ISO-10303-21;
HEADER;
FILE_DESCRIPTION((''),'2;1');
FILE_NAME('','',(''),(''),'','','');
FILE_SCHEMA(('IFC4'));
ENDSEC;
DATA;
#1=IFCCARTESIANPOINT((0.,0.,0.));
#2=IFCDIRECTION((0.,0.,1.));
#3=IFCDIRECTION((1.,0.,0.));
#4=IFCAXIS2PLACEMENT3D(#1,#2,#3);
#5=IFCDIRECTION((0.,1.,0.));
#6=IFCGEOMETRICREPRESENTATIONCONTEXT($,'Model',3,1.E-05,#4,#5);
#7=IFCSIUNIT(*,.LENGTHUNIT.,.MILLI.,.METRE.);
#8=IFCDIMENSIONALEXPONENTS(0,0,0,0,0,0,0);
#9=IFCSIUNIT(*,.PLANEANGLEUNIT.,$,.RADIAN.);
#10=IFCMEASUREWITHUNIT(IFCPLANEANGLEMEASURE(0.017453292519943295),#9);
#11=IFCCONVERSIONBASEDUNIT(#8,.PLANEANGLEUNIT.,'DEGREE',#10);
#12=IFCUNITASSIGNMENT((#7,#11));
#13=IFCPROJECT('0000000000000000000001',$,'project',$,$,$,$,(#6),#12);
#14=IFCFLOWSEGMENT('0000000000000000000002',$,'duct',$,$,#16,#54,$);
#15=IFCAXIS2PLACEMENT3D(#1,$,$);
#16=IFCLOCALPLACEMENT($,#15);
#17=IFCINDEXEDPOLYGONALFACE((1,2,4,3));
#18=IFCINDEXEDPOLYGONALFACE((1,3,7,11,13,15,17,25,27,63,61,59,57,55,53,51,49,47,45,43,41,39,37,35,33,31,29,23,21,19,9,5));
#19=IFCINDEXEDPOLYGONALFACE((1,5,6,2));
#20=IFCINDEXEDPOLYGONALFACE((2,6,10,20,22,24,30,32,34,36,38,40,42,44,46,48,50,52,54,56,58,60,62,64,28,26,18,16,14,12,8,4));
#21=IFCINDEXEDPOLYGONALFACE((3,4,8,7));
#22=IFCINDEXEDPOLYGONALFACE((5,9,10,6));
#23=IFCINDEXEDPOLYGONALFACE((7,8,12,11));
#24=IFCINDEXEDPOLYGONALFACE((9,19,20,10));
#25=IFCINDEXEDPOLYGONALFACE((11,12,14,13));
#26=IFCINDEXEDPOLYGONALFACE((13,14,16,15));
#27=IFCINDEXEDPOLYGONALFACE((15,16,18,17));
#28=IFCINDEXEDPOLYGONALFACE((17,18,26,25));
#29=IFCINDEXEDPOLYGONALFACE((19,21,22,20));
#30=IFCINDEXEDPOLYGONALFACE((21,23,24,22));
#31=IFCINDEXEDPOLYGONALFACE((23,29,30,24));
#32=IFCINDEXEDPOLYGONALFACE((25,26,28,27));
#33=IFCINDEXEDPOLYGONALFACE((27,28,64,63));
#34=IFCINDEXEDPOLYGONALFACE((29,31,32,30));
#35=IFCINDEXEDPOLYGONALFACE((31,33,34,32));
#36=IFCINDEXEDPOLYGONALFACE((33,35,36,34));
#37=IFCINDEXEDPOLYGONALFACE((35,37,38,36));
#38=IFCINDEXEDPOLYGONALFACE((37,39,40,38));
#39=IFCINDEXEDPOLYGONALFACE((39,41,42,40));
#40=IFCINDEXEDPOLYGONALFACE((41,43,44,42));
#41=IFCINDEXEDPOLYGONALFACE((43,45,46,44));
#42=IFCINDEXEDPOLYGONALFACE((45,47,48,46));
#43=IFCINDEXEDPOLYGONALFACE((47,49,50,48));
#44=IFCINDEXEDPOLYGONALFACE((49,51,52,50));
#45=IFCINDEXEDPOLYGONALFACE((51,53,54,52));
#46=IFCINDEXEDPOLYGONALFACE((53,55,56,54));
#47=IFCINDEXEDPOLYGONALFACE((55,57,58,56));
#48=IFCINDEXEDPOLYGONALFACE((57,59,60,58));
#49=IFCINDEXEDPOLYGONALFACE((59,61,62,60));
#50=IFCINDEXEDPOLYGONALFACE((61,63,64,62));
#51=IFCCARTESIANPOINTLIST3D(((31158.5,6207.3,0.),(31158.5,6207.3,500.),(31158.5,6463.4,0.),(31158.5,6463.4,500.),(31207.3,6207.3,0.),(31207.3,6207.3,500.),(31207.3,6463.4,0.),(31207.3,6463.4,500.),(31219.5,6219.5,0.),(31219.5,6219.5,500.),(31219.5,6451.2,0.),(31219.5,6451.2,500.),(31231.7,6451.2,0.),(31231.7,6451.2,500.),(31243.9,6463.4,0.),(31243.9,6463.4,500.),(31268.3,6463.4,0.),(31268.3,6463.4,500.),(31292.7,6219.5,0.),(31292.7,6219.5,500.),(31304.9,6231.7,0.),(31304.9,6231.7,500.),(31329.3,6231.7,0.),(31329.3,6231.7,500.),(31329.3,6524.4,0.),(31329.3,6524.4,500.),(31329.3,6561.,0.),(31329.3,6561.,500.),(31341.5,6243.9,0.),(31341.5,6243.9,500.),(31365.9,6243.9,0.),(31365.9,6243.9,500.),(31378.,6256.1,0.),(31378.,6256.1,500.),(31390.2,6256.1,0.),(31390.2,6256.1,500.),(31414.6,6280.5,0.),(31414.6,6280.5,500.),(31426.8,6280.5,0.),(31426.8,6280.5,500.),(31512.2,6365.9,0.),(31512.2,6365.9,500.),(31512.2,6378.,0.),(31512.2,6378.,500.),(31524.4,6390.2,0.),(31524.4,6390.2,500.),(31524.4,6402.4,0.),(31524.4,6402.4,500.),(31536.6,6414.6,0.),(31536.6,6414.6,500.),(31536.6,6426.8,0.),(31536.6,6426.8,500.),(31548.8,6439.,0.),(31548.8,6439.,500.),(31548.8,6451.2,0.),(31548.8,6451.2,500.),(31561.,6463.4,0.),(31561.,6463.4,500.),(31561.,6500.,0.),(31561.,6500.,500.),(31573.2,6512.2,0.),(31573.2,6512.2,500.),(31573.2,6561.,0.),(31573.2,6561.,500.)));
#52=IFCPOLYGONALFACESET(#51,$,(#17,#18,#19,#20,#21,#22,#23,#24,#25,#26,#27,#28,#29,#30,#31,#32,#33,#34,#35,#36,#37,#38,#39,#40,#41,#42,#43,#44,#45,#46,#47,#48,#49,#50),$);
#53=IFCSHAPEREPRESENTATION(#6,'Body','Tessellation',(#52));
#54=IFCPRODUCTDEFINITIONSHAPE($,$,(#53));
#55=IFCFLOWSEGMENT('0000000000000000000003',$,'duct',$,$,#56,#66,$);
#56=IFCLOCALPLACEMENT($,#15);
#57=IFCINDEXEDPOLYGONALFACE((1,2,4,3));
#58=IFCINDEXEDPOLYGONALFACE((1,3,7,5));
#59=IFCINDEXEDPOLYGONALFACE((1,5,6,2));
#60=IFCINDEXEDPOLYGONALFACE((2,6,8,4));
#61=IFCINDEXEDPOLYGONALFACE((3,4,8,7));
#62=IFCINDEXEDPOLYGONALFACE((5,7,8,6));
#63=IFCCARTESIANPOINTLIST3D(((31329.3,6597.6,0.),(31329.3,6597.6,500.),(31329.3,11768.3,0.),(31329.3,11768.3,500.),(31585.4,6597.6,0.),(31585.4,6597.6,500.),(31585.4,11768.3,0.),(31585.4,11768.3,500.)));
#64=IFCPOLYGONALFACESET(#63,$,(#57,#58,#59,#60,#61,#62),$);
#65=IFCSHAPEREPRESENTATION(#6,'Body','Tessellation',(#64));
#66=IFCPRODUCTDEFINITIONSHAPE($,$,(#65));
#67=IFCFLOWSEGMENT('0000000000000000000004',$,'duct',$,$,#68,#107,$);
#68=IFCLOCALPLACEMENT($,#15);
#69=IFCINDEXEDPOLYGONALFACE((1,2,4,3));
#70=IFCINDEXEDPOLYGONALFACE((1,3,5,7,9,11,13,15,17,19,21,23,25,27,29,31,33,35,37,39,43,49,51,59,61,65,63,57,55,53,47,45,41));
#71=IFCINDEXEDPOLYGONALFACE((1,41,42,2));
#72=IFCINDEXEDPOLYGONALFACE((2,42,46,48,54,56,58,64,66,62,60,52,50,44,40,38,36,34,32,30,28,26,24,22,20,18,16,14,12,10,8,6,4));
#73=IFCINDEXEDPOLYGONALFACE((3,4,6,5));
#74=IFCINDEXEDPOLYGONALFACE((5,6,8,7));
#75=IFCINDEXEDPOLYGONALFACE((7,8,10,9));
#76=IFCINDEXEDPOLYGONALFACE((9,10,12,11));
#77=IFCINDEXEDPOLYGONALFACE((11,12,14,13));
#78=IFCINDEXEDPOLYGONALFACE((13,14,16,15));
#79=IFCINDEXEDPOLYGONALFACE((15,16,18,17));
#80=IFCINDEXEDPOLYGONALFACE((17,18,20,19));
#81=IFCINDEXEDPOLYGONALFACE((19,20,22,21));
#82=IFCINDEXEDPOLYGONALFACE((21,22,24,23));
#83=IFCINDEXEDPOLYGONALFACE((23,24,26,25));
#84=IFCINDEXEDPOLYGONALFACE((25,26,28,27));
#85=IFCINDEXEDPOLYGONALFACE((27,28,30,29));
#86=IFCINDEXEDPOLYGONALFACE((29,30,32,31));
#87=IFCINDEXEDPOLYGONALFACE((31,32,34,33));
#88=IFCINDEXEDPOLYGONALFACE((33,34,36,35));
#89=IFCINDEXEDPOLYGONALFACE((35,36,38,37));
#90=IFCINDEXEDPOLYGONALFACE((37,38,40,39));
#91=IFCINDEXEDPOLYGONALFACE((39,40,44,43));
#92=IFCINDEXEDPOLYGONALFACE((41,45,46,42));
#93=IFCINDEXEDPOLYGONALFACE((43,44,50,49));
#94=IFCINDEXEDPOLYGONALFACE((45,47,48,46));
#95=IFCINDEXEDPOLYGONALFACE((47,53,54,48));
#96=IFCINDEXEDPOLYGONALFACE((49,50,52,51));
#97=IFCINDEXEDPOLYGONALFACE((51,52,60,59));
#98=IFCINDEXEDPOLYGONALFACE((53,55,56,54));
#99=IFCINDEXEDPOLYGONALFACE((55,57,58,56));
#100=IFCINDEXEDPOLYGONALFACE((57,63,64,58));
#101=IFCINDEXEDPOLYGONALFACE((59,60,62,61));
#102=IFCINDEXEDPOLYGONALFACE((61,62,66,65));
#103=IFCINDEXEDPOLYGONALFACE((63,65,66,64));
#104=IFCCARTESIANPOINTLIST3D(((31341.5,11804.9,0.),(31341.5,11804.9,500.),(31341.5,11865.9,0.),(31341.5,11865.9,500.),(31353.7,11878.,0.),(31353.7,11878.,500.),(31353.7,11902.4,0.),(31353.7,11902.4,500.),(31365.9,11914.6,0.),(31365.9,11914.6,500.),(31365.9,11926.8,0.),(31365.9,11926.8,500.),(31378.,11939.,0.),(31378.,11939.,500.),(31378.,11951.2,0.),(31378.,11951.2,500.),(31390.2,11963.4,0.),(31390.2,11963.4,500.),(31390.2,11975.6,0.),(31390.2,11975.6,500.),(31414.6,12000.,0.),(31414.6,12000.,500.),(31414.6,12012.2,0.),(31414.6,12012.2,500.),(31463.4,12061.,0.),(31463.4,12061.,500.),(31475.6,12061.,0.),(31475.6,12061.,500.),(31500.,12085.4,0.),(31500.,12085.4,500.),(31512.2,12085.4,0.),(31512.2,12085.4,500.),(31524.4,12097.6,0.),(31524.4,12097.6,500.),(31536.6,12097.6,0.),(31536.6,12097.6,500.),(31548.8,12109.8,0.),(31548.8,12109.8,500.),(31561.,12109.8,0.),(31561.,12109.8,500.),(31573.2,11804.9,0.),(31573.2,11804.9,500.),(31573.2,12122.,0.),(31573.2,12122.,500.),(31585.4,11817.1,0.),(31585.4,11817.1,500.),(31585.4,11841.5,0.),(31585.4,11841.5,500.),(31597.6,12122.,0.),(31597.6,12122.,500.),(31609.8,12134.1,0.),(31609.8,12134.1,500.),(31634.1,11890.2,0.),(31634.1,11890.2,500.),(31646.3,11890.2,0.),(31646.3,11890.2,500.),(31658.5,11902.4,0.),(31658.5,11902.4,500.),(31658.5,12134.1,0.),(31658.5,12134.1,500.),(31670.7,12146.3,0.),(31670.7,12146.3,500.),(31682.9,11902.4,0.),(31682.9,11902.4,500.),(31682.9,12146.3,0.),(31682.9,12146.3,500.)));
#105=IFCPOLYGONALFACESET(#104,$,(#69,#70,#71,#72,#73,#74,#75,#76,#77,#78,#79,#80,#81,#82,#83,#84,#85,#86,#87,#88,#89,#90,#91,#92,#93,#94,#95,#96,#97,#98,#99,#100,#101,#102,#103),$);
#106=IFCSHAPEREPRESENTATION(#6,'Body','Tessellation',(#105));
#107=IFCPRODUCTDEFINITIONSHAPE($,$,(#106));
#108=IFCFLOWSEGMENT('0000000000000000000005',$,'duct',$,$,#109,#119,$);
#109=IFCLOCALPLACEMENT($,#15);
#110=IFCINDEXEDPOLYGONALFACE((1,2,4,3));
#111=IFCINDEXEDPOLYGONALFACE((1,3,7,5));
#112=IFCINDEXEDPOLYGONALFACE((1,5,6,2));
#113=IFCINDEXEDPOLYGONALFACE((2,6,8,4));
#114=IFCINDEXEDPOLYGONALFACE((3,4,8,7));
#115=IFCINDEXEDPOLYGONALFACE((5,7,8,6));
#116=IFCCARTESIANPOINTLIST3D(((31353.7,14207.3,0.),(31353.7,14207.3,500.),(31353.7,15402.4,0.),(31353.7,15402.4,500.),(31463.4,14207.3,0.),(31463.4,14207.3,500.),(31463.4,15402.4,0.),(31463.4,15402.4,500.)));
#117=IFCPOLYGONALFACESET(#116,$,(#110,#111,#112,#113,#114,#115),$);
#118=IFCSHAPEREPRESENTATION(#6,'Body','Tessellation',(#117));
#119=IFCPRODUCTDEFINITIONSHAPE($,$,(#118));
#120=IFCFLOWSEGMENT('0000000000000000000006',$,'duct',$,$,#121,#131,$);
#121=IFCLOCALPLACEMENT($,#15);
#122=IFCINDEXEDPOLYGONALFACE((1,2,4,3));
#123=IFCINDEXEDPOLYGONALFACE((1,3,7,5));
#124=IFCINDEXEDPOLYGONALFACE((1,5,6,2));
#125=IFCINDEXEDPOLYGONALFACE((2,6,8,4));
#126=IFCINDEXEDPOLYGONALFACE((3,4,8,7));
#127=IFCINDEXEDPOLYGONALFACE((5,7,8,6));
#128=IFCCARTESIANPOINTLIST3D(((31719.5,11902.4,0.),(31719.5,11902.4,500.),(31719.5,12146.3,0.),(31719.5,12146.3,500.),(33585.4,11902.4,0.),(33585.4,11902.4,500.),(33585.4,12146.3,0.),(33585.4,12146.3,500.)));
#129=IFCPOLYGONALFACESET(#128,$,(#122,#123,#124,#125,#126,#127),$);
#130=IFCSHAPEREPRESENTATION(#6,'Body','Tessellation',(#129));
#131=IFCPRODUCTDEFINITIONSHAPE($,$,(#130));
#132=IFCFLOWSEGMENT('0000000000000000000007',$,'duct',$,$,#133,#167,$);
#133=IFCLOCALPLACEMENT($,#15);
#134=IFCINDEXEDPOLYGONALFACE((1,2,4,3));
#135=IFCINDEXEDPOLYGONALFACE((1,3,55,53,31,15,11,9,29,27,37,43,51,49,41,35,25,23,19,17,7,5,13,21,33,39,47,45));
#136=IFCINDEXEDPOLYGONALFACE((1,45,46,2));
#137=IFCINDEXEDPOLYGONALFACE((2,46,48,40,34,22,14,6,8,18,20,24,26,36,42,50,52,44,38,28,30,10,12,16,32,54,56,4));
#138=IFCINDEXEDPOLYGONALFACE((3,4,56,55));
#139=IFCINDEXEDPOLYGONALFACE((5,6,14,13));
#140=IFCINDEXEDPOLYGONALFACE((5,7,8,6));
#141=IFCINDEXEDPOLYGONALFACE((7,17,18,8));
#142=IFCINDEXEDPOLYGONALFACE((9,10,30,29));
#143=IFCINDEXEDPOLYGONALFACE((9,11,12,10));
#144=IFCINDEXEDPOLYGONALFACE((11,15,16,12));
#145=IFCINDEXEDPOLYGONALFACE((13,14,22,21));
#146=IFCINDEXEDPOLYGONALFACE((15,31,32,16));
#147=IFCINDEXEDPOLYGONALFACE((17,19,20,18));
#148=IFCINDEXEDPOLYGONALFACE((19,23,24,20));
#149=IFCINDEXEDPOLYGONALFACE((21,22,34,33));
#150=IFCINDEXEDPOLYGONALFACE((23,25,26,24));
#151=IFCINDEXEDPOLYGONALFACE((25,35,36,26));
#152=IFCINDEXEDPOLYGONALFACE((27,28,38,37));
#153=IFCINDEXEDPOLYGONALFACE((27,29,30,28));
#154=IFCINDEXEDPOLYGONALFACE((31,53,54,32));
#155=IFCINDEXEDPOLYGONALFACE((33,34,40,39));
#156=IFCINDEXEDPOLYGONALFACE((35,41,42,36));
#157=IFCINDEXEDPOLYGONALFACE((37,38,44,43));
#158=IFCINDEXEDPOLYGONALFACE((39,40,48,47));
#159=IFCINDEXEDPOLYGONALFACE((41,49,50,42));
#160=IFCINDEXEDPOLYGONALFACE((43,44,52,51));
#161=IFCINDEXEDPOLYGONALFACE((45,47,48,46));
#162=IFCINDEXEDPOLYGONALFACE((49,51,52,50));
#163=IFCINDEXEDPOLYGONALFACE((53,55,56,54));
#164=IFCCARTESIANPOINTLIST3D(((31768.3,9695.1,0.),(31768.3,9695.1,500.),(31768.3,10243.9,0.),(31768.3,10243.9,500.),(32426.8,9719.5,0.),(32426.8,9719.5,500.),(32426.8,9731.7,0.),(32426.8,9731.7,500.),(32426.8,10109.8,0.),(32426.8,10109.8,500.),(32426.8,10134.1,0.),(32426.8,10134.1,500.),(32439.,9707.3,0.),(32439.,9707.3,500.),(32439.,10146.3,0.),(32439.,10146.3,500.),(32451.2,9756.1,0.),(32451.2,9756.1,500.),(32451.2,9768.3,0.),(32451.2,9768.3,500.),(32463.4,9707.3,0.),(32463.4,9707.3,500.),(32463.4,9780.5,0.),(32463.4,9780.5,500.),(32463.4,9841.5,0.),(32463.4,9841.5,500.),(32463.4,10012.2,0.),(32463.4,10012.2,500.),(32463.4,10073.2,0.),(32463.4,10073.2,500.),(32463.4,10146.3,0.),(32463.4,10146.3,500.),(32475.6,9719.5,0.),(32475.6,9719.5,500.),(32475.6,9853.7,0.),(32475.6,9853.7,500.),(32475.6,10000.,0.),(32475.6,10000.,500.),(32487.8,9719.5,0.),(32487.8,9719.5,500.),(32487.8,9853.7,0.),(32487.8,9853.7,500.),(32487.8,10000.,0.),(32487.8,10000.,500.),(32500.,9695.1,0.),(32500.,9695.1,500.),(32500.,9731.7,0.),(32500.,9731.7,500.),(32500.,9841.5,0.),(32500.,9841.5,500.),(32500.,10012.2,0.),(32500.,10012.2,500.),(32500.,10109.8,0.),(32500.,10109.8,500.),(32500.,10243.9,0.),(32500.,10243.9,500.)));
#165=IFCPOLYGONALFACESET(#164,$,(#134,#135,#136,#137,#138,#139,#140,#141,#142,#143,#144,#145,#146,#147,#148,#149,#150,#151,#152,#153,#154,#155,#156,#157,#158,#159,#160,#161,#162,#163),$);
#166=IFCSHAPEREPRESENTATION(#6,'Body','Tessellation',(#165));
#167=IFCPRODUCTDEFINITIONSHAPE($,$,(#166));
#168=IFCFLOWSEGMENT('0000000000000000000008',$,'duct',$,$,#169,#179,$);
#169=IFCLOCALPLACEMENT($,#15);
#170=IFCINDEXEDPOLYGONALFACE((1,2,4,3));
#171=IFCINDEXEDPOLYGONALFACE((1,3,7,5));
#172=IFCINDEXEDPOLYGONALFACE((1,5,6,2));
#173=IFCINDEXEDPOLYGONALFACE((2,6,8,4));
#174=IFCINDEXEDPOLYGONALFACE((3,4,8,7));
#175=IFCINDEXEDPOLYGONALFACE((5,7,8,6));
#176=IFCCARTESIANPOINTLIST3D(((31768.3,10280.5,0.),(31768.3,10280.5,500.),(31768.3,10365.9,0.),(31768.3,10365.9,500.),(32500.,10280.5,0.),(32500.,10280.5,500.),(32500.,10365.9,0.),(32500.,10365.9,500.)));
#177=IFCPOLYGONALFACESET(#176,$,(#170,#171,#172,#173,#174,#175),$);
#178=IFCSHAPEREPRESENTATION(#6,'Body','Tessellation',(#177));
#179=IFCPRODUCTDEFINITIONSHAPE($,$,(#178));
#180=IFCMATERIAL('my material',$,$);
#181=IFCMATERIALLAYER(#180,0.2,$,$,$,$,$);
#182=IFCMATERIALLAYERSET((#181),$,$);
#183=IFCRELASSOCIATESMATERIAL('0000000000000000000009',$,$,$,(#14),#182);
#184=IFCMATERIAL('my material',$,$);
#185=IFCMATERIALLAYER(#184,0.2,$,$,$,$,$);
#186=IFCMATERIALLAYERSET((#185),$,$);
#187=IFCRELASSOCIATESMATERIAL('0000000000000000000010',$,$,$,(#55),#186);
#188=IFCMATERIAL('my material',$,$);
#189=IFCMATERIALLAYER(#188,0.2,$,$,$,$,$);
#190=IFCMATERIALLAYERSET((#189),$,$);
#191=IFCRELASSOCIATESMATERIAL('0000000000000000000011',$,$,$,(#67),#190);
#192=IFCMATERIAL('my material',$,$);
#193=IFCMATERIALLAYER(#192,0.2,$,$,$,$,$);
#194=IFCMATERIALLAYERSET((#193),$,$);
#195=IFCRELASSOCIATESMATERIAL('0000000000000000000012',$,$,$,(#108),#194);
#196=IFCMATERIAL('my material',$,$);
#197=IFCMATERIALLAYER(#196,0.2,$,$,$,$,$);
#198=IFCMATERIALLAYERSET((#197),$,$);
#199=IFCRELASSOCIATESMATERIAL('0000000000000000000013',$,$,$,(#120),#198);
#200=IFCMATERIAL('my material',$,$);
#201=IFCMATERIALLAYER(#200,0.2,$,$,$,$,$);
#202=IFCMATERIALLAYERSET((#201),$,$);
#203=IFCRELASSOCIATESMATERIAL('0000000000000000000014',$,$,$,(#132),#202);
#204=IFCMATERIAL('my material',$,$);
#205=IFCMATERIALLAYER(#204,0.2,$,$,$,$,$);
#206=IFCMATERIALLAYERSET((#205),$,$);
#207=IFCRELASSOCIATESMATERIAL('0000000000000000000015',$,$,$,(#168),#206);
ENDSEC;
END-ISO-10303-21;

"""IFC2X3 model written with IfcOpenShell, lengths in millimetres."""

from ifc_helpers import new_model, entity, si_unit, converted_unit, direction, origin_with_axes, place, context, project, polyline, outline, extrude, material, layer, layer_set, layer_usage, element, save


model = new_model("IFC2X3")

# Units and contexts
model_context = context("Model", 3, precision=1e-05, world=origin_with_axes(), true_north=direction((0.0, 1.0, 0.0)))
ifc_project = project(units=[si_unit("LENGTHUNIT", "METRE", prefix="MILLI"), converted_unit("PLANEANGLEUNIT", "DEGREE", entity("IfcPlaneAngleMeasure", 0.017453292519943295), si_unit("PLANEANGLEUNIT", "RADIAN"), dimensions=[0, 0, 0, 0, 0, 0, 0])], contexts=[model_context])

# Flow segments
ifc_material_1 = material(Name="my material")
ifc_layer_1 = layer(ifc_material_1, 0.2)
ifc_layer_set_1 = layer_set([ifc_layer_1])
ifc_layer_usage_1 = layer_usage(ifc_layer_set_1, "AXIS2", "POSITIVE", -0.1)
flow_segment_1_placement = place(None, origin_with_axes())
element("IfcFlowSegment", 1, at=flow_segment_1_placement, material=ifc_layer_usage_1, Name="duct", context=model_context, shape_type="SweptSolid", body=[
    extrude(outline(polyline([(31158.5, 6207.3), (31207.3, 6207.3), (31219.5, 6219.5), (31292.7, 6219.5), (31304.9, 6231.7), (31329.3, 6231.7), (31341.5, 6243.9), (31365.9, 6243.9), (31378.0, 6256.1), (31390.2, 6256.1), (31414.6, 6280.5), (31426.8, 6280.5), (31512.2, 6365.9), (31512.2, 6378.0), (31524.4, 6390.2), (31524.4, 6402.4), (31536.6, 6414.6), (31536.6, 6426.8), (31548.8, 6439.0), (31548.8, 6451.2), (31561.0, 6463.4), (31561.0, 6500.0), (31573.2, 6512.2), (31573.2, 6561.0), (31329.3, 6561.0), (31329.3, 6524.4), (31268.3, 6463.4), (31243.9, 6463.4), (31231.7, 6451.2), (31219.5, 6451.2), (31207.3, 6463.4), (31158.5, 6463.4), (31158.5, 6207.3)])), origin_with_axes(), (0.0, 0.0, 1.0), 500.0),
])
ifc_material_2 = material(Name="my material")
ifc_layer_2 = layer(ifc_material_2, 0.2)
ifc_layer_set_2 = layer_set([ifc_layer_2])
ifc_layer_usage_2 = layer_usage(ifc_layer_set_2, "AXIS2", "POSITIVE", -0.1)
flow_segment_2_placement = place(None, origin_with_axes())
element("IfcFlowSegment", 2, at=flow_segment_2_placement, material=ifc_layer_usage_2, Name="duct", context=model_context, shape_type="SweptSolid", body=[
    extrude(outline(polyline([(31329.3, 6597.6), (31585.4, 6597.6), (31585.4, 11768.3), (31329.3, 11768.3), (31329.3, 6597.6)])), origin_with_axes(), (0.0, 0.0, 1.0), 500.0),
])
ifc_material_3 = material(Name="my material")
ifc_layer_3 = layer(ifc_material_3, 0.2)
ifc_layer_set_3 = layer_set([ifc_layer_3])
ifc_layer_usage_3 = layer_usage(ifc_layer_set_3, "AXIS2", "POSITIVE", -0.1)
flow_segment_3_placement = place(None, origin_with_axes())
element("IfcFlowSegment", 3, at=flow_segment_3_placement, material=ifc_layer_usage_3, Name="duct", context=model_context, shape_type="SweptSolid", body=[
    extrude(outline(polyline([(31341.5, 11804.9), (31573.2, 11804.9), (31585.4, 11817.1), (31585.4, 11841.5), (31634.1, 11890.2), (31646.3, 11890.2), (31658.5, 11902.4), (31682.9, 11902.4), (31682.9, 12146.3), (31670.7, 12146.3), (31658.5, 12134.1), (31609.8, 12134.1), (31597.6, 12122.0), (31573.2, 12122.0), (31561.0, 12109.8), (31548.8, 12109.8), (31536.6, 12097.6), (31524.4, 12097.6), (31512.2, 12085.4), (31500.0, 12085.4), (31475.6, 12061.0), (31463.4, 12061.0), (31414.6, 12012.2), (31414.6, 12000.0), (31390.2, 11975.6), (31390.2, 11963.4), (31378.0, 11951.2), (31378.0, 11939.0), (31365.9, 11926.8), (31365.9, 11914.6), (31353.7, 11902.4), (31353.7, 11878.0), (31341.5, 11865.9), (31341.5, 11804.9)])), origin_with_axes(), (0.0, 0.0, 1.0), 500.0),
])
ifc_material_4 = material(Name="my material")
ifc_layer_4 = layer(ifc_material_4, 0.2)
ifc_layer_set_4 = layer_set([ifc_layer_4])
ifc_layer_usage_4 = layer_usage(ifc_layer_set_4, "AXIS2", "POSITIVE", -0.1)
flow_segment_4_placement = place(None, origin_with_axes())
element("IfcFlowSegment", 4, at=flow_segment_4_placement, material=ifc_layer_usage_4, Name="duct", context=model_context, shape_type="SweptSolid", body=[
    extrude(outline(polyline([(31353.7, 14207.3), (31463.4, 14207.3), (31463.4, 15402.4), (31353.7, 15402.4), (31353.7, 14207.3)])), origin_with_axes(), (0.0, 0.0, 1.0), 500.0),
])
ifc_material_5 = material(Name="my material")
ifc_layer_5 = layer(ifc_material_5, 0.2)
ifc_layer_set_5 = layer_set([ifc_layer_5])
ifc_layer_usage_5 = layer_usage(ifc_layer_set_5, "AXIS2", "POSITIVE", -0.1)
flow_segment_5_placement = place(None, origin_with_axes())
element("IfcFlowSegment", 5, at=flow_segment_5_placement, material=ifc_layer_usage_5, Name="duct", context=model_context, shape_type="SweptSolid", body=[
    extrude(outline(polyline([(31719.5, 11902.4), (33585.4, 11902.4), (33585.4, 12146.3), (31719.5, 12146.3), (31719.5, 11902.4)])), origin_with_axes(), (0.0, 0.0, 1.0), 500.0),
])
ifc_material_6 = material(Name="my material")
ifc_layer_6 = layer(ifc_material_6, 0.2)
ifc_layer_set_6 = layer_set([ifc_layer_6])
ifc_layer_usage_6 = layer_usage(ifc_layer_set_6, "AXIS2", "POSITIVE", -0.1)
flow_segment_6_placement = place(None, origin_with_axes())
element("IfcFlowSegment", 6, at=flow_segment_6_placement, material=ifc_layer_usage_6, Name="duct", context=model_context, shape_type="SweptSolid", body=[
    extrude(outline(polyline([(31768.3, 9695.1), (32500.0, 9695.1), (32500.0, 9756.1), (32500.0, 9731.7), (32487.8, 9719.5), (32475.6, 9719.5), (32463.4, 9707.3), (32439.0, 9707.3), (32426.8, 9719.5), (32426.8, 9731.7), (32451.2, 9756.1), (32451.2, 9768.3), (32463.4, 9780.5), (32463.4, 9841.5), (32475.6, 9853.7), (32487.8, 9853.7), (32500.0, 9841.5), (32500.0, 9792.7), (32500.0, 10061.0), (32500.0, 10012.2), (32487.8, 10000.0), (32475.6, 10000.0), (32463.4, 10012.2), (32463.4, 10073.2), (32426.8, 10109.8), (32426.8, 10134.1), (32439.0, 10146.3), (32463.4, 10146.3), (32500.0, 10109.8), (32500.0, 10097.6), (32500.0, 10243.9), (31768.3, 10243.9), (31768.3, 9695.1)])), origin_with_axes(), (0.0, 0.0, 1.0), 500.0),
])
ifc_material_7 = material(Name="my material")
ifc_layer_7 = layer(ifc_material_7, 0.2)
ifc_layer_set_7 = layer_set([ifc_layer_7])
ifc_layer_usage_7 = layer_usage(ifc_layer_set_7, "AXIS2", "POSITIVE", -0.1)
flow_segment_7_placement = place(None, origin_with_axes())
element("IfcFlowSegment", 7, at=flow_segment_7_placement, material=ifc_layer_usage_7, Name="duct", context=model_context, shape_type="SweptSolid", body=[
    extrude(outline(polyline([(31768.3, 10280.5), (32500.0, 10280.5), (32500.0, 10365.9), (31768.3, 10365.9), (31768.3, 10280.5)])), origin_with_axes(), (0.0, 0.0, 1.0), 500.0),
])

save(model, "model.ifc")
